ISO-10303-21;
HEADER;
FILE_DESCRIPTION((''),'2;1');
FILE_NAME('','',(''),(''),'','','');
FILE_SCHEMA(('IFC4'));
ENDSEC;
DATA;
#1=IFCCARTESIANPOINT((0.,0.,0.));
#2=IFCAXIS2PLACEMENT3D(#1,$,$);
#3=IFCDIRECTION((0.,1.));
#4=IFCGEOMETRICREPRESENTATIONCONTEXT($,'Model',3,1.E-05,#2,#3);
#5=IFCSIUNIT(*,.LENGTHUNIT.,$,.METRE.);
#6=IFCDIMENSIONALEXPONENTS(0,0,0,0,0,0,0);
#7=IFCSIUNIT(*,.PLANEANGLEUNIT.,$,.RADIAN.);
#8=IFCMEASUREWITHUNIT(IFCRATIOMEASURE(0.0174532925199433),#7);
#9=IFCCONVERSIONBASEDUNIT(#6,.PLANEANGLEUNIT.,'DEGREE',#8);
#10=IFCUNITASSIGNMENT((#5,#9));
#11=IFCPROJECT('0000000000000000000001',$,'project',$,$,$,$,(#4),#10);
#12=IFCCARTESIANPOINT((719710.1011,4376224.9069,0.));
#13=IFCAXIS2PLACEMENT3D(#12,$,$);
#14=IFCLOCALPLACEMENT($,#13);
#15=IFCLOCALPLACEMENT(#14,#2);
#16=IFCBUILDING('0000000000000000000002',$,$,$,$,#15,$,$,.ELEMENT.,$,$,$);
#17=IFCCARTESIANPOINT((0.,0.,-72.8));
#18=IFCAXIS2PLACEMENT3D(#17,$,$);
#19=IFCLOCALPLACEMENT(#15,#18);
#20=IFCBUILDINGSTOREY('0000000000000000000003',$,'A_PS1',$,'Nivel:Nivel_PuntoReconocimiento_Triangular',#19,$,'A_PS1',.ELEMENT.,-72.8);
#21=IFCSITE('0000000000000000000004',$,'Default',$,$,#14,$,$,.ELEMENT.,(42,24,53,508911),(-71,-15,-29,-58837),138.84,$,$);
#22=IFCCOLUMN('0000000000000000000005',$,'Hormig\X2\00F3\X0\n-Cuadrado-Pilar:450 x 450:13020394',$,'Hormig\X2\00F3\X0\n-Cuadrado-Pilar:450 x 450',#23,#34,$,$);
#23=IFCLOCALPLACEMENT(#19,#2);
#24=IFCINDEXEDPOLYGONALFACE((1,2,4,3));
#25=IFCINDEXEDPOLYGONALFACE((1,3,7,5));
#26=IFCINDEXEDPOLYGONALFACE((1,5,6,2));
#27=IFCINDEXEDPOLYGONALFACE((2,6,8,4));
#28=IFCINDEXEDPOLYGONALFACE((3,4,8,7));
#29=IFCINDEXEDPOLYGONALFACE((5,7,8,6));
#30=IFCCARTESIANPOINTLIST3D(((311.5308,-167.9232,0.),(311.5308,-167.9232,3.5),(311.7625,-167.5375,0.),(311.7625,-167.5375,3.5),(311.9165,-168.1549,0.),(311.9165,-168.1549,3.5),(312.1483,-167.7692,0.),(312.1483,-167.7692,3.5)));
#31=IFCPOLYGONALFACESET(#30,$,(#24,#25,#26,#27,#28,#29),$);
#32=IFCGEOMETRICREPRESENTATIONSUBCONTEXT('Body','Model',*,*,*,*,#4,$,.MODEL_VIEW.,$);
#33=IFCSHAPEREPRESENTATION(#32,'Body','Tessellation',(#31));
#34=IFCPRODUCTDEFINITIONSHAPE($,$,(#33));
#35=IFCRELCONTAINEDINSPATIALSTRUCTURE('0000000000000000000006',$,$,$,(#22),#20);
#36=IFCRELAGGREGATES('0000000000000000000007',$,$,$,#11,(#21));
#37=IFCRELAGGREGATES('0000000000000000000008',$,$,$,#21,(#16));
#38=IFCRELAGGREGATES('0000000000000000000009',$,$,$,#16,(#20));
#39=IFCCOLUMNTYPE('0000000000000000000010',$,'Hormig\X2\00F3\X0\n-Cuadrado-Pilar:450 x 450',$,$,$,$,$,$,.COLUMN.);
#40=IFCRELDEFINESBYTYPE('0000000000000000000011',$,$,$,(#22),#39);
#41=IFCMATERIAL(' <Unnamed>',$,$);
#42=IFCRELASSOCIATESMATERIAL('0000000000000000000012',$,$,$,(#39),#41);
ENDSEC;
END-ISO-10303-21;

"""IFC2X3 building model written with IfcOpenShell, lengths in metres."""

from ifc_helpers import new_model, entity, si_unit, converted_unit, direction, frame, origin, origin_2d_with_axis, place, context, subcontext, project, spatial, rectangle, extrude, source, transform, mapped, material, type_object, type_shapes, element, save


model = new_model("IFC2X3")

# Units and contexts
model_context = context("Model", 3, precision=1e-05, world=origin(), true_north=direction((0.0, 1.0)))
body_context = subcontext(model_context, "Body", "Model", "MODEL_VIEW")
ifc_project = project(units=[si_unit("LENGTHUNIT", "METRE"), converted_unit("PLANEANGLEUNIT", "DEGREE", entity("IfcRatioMeasure", 0.0174532925199433), si_unit("PLANEANGLEUNIT", "RADIAN"), dimensions=[0, 0, 0, 0, 0, 0, 0])], contexts=[model_context])

# Site, building, storey
site_placement = place(None, frame((719710.1011, 4376224.9069, 0.0)))
site = spatial("IfcSite", under=ifc_project, at=site_placement, Name="Default", CompositionType="ELEMENT", RefLatitude=(42, 24, 53, 508911), RefLongitude=(-71, -15, -29, -58837), RefElevation=138.84)
building_placement = place(site_placement, origin())
building = spatial("IfcBuilding", under=site, at=building_placement, CompositionType="ELEMENT")
storey_placement = place(building_placement, frame((0.0, 0.0, -72.8)))
storey = spatial("IfcBuildingStorey", under=building, at=storey_placement, Name="A_PS1", ObjectType="Nivel:Nivel_PuntoReconocimiento_Triangular", LongName="A_PS1", CompositionType="ELEMENT", Elevation=-72.8)

# Column
ifc_material = material(Name=" <Unnamed>")
column_type = type_object("IfcColumnType", Name="Hormigón-Cuadrado-Pilar:450 x 450", PredefinedType="COLUMN", material=ifc_material)
shared_shape = source(origin(), body_context, "Body", "SweptSolid", [
    extrude(rectangle(XDim=0.45, YDim=0.45, at=origin_2d_with_axis()), frame((0.0, 0.0, -72.8), z_axis=(0.0, 0.0, 1.0), x_axis=(0.0, -1.0, 0.0)), (0.0, 0.0, 1.0), 3.5),
])
type_shapes(column_type, [shared_shape])
for number, where, z_axis, x_axis, name in (
    (1, (311.8395, -167.8462, 72.8), (0.0, 0.0, 1.0), (0.857167, -0.515038, 0.0), "Hormigón-Cuadrado-Pilar:450 x 450:13020394"),
):
    element("IfcColumn", number, at=place(storey_placement, frame(where, z_axis=z_axis, x_axis=x_axis)), inside=storey, type_object=column_type, Name=name, ObjectType="Hormigón-Cuadrado-Pilar:450 x 450", context=body_context, shape_type="MappedRepresentation", body=[
        mapped(shared_shape, transform((0.0, 0.0, 0.0), scale=1.0)),
    ])

save(model, "model.ifc")
